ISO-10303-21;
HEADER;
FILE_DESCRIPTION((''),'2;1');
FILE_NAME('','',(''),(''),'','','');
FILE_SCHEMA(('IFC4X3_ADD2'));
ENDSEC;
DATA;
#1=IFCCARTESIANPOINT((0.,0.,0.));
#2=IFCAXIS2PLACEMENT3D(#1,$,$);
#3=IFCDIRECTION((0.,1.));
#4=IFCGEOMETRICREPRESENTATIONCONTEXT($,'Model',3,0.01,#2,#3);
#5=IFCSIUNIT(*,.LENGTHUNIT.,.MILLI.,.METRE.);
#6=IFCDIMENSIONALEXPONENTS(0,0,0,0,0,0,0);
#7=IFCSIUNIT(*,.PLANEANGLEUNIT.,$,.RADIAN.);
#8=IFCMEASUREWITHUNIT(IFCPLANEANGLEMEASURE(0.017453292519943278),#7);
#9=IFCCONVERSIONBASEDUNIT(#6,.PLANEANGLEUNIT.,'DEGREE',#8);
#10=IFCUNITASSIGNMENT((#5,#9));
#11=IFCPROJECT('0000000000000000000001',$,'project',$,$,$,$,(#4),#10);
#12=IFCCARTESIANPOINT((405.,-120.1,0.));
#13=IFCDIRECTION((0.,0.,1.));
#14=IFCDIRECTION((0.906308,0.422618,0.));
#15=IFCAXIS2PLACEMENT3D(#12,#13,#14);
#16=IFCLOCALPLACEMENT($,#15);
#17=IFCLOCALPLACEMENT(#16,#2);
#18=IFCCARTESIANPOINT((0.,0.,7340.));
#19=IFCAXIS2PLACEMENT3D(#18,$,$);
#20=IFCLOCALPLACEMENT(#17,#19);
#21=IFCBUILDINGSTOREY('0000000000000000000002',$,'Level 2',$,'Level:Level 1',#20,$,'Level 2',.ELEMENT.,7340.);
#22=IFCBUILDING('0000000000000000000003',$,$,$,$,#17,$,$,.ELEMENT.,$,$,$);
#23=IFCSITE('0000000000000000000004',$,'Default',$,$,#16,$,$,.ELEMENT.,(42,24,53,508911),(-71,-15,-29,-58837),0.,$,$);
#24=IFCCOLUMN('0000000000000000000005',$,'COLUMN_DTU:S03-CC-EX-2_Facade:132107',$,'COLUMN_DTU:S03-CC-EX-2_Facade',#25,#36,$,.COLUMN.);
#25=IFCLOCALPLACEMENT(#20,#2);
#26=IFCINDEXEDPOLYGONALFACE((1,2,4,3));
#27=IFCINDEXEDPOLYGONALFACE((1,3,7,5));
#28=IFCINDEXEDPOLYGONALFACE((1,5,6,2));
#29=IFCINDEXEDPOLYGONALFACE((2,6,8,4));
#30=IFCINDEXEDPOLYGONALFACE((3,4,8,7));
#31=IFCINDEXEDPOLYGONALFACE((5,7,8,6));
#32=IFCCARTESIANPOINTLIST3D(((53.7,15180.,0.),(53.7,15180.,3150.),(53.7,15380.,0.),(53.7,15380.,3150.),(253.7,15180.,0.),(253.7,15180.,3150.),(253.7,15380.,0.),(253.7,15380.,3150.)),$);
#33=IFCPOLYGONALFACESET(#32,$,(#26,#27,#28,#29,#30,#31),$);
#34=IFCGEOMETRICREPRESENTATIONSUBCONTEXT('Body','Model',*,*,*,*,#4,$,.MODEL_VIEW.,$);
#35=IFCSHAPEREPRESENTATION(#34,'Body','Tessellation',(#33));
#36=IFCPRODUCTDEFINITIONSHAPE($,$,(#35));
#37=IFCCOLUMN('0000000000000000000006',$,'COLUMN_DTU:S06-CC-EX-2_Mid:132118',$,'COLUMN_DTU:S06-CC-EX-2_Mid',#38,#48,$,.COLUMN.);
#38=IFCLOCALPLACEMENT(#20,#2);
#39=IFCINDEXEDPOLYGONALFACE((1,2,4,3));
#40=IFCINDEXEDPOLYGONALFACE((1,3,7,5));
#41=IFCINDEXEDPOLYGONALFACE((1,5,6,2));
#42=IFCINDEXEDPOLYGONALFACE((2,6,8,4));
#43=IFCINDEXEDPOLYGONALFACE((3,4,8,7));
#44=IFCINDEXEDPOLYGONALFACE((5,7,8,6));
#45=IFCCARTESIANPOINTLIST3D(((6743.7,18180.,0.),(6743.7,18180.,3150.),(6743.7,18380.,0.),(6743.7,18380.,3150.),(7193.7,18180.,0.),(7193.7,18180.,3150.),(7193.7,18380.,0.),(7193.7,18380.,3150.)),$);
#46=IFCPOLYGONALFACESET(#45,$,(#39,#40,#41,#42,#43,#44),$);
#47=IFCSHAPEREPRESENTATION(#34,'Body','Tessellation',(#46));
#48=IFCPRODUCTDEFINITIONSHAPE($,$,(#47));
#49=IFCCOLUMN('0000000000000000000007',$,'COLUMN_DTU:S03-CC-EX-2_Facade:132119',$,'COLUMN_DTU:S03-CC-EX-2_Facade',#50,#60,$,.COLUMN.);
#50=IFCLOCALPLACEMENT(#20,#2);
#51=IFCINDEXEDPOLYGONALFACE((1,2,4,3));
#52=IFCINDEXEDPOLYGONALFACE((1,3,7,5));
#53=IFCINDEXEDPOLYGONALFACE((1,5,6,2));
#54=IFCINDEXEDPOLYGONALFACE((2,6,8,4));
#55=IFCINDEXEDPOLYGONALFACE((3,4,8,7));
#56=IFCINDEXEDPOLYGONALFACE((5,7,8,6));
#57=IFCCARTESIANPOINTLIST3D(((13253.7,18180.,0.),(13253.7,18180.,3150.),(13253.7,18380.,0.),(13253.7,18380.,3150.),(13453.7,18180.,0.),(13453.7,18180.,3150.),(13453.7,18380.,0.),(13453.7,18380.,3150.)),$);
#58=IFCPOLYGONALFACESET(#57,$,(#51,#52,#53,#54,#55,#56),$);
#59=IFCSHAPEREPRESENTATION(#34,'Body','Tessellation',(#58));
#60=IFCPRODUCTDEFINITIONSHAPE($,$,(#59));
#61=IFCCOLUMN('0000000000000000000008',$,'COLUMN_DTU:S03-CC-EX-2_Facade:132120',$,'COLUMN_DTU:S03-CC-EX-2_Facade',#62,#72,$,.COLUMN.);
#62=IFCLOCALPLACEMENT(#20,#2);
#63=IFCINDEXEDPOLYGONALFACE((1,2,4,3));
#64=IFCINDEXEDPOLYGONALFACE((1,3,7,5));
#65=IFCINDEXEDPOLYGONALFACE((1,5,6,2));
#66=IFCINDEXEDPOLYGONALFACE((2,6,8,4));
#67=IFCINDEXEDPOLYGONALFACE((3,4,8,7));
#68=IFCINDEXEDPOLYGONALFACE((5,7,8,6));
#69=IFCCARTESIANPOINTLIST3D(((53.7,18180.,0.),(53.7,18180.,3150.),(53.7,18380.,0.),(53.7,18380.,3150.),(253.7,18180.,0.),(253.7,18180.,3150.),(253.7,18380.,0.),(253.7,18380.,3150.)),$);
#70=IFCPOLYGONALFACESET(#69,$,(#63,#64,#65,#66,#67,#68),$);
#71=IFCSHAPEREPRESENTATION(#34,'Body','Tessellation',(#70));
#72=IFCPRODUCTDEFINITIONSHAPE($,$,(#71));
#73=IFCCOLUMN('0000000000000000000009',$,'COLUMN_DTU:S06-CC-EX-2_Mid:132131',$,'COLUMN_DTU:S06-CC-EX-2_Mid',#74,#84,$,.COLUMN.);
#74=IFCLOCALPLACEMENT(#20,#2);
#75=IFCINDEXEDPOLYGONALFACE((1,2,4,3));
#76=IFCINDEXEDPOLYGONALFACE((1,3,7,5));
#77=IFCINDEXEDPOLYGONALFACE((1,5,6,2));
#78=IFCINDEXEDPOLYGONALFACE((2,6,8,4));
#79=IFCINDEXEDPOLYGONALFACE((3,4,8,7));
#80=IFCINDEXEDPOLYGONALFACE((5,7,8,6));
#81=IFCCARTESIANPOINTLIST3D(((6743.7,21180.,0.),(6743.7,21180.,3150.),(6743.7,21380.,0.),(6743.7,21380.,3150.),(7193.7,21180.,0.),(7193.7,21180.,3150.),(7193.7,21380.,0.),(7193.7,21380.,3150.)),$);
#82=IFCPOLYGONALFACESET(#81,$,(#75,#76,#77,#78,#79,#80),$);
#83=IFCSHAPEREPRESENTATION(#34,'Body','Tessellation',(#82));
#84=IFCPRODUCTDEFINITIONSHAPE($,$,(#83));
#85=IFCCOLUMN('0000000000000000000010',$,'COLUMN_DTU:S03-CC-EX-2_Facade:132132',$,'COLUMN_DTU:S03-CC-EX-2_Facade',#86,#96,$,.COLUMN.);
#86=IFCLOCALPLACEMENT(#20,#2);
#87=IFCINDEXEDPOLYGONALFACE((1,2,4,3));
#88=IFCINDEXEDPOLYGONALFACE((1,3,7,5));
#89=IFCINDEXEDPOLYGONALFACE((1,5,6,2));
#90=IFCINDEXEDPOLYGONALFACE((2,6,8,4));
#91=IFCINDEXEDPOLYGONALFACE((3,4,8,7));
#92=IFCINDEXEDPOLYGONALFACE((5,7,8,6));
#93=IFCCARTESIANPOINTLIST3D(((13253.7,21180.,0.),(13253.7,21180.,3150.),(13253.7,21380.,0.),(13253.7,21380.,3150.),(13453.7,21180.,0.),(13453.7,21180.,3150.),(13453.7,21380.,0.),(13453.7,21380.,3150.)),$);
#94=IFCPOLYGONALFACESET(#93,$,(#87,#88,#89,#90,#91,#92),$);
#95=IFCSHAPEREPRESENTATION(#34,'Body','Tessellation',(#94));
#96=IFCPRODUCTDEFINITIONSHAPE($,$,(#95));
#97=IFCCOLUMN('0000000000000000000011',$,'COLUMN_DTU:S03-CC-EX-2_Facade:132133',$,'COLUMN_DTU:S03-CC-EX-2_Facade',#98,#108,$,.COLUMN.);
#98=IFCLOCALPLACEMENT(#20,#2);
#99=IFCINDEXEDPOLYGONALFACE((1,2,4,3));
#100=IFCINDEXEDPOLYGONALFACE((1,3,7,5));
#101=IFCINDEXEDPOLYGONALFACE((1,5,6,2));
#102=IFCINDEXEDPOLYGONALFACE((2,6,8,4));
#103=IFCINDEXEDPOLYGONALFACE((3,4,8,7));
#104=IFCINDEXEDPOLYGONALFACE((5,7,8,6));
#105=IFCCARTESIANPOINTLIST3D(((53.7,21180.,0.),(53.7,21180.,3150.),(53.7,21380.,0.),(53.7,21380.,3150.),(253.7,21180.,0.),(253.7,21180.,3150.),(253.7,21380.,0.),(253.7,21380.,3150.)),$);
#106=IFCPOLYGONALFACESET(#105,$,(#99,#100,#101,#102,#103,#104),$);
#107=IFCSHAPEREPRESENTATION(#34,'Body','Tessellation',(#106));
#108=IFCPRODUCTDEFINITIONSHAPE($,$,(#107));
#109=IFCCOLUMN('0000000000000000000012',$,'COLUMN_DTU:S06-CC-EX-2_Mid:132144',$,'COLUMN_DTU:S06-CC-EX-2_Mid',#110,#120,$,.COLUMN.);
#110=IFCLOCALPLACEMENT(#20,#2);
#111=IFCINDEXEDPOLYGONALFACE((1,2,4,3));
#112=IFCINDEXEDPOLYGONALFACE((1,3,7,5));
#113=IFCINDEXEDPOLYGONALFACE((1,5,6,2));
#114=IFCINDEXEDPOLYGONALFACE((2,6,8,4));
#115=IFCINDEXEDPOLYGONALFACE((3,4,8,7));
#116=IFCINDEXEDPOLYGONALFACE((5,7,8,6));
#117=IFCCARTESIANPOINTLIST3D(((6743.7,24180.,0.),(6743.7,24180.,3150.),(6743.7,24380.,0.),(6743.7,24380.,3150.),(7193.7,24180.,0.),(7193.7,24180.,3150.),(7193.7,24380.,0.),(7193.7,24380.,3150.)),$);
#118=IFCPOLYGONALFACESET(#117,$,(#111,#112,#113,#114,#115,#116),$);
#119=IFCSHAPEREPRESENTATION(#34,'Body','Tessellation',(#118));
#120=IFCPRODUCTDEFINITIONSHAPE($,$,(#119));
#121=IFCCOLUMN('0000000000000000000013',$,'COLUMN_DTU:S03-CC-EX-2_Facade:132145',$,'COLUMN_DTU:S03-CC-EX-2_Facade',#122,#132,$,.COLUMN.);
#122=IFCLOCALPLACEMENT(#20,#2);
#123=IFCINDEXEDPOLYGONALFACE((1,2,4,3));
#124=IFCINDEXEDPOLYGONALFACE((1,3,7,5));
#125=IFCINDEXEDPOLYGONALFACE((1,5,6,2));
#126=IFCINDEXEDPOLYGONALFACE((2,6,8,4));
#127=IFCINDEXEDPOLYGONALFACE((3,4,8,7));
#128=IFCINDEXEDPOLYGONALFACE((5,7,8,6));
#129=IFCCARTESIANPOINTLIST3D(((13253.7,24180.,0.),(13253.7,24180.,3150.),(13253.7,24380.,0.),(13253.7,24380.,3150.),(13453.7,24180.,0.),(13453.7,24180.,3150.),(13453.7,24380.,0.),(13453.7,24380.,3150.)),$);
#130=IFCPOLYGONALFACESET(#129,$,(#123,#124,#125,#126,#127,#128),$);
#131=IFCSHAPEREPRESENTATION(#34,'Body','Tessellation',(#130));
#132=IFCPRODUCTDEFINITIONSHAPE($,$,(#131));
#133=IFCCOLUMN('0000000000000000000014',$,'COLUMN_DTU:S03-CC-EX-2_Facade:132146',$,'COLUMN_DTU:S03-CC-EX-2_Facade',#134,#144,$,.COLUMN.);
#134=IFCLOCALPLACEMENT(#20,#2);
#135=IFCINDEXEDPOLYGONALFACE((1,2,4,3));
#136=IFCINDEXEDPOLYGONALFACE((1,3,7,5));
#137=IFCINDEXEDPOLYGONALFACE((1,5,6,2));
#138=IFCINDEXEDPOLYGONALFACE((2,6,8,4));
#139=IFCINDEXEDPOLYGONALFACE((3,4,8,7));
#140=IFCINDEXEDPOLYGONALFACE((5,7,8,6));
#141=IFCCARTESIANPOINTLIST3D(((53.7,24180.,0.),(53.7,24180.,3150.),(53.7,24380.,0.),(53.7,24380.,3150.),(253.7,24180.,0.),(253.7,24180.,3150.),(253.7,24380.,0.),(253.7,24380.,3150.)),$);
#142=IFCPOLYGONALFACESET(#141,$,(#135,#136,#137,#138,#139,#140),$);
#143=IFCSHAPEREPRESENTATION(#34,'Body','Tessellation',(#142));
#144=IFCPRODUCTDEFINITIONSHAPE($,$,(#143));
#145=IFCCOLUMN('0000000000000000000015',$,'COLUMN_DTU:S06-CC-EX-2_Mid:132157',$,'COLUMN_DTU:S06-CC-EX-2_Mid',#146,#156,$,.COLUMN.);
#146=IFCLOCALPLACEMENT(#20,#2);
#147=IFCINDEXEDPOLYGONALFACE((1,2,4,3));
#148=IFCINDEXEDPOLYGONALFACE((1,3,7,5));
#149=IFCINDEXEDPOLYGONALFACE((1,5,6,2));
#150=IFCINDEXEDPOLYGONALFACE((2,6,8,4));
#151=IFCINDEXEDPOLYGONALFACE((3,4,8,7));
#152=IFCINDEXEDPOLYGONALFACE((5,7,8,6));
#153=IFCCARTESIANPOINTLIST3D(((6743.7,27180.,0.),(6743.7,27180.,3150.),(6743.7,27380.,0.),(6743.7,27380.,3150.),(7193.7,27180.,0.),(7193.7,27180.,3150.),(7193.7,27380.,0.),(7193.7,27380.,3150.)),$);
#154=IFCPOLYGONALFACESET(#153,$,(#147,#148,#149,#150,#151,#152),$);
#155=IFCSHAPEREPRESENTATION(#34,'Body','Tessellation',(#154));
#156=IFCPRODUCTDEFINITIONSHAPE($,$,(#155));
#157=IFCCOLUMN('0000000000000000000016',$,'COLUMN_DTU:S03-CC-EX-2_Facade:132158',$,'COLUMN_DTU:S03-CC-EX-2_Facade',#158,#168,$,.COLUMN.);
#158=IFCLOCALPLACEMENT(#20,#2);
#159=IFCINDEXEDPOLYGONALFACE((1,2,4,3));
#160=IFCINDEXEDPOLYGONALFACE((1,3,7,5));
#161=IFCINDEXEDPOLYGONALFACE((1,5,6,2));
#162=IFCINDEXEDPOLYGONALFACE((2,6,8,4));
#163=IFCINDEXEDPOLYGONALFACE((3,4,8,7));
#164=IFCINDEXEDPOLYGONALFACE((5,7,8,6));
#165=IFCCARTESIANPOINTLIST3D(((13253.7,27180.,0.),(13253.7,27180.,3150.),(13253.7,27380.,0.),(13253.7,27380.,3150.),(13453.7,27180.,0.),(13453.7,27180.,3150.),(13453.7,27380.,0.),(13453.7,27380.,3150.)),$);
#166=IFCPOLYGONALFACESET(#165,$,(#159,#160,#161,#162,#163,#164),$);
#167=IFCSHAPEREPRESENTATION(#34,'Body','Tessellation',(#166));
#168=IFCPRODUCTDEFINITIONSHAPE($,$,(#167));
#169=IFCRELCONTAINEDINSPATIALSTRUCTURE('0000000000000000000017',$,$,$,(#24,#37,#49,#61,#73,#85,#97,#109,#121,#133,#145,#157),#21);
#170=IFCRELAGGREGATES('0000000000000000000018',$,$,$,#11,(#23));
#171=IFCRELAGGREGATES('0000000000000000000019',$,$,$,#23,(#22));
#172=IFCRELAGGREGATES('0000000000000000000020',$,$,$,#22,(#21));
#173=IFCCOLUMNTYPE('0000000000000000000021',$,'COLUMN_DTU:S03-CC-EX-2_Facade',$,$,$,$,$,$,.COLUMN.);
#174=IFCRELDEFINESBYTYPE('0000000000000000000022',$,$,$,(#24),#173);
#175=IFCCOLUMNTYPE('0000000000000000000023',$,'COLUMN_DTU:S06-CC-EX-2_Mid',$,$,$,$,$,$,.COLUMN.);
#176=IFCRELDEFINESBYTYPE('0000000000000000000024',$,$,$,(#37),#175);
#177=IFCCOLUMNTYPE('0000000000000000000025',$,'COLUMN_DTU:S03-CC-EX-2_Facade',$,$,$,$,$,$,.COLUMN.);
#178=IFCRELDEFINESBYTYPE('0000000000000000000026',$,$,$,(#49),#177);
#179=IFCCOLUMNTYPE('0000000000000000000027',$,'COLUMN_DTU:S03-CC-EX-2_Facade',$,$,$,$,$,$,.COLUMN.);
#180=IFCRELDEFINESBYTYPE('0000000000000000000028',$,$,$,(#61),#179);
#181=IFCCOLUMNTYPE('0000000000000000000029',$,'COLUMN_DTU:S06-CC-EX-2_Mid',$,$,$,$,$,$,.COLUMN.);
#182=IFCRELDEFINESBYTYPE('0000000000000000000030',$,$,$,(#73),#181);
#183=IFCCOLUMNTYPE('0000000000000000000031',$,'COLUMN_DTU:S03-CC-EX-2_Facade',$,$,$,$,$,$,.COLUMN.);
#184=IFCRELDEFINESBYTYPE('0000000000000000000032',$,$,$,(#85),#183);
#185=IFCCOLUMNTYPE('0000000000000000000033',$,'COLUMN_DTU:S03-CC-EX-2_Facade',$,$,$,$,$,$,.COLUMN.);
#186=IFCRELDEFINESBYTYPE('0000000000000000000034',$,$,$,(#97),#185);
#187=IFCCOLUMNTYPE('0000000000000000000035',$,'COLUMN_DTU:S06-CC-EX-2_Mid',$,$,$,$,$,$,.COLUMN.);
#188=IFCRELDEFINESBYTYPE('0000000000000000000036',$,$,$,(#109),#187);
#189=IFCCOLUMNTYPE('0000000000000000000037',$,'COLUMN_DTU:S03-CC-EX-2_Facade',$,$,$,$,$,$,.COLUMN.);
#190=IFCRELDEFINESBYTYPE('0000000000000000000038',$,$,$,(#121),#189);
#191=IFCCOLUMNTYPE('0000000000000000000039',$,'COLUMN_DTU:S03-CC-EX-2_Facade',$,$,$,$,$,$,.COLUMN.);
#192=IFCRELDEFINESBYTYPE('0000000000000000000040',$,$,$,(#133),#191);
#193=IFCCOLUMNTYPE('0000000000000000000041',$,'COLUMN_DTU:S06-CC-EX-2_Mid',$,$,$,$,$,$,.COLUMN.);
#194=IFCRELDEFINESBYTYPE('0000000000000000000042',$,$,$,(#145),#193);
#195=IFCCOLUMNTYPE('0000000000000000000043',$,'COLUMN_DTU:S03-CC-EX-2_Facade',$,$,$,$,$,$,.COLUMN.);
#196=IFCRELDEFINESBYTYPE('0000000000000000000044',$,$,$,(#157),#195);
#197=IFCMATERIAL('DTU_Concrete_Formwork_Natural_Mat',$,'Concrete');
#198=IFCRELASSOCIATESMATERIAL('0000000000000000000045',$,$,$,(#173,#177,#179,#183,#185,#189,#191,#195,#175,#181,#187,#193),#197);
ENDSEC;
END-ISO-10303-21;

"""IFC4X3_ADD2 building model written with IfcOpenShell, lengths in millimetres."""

from ifc_helpers import new_model, entity, si_unit, converted_unit, direction, frame, frame_2d, origin, origin_2d_with_axis, place, context, subcontext, project, spatial, rectangle, extrude, source, transform, mapped, material, material_profile, profile_set, type_object, type_shapes, element, save


model = new_model("IFC4X3_ADD2")

# Units and contexts
model_context = context("Model", 3, precision=0.01, world=origin(), true_north=direction((0.0, 1.0)))
body_context = subcontext(model_context, "Body", "Model", "MODEL_VIEW")
ifc_project = project(units=[si_unit("LENGTHUNIT", "METRE", prefix="MILLI"), converted_unit("PLANEANGLEUNIT", "DEGREE", entity("IfcPlaneAngleMeasure", 0.017453292519943278), si_unit("PLANEANGLEUNIT", "RADIAN"), dimensions=[0, 0, 0, 0, 0, 0, 0])], contexts=[model_context])

# Site, building, storey
site_placement = place(None, frame((405.0, -120.1, 0.0), z_axis=(0.0, 0.0, 1.0), x_axis=(0.906308, 0.422618, 0.0)))
site = spatial("IfcSite", under=ifc_project, at=site_placement, Name="Default", CompositionType="ELEMENT", RefLatitude=(42, 24, 53, 508911), RefLongitude=(-71, -15, -29, -58837), RefElevation=0.0)
building_placement = place(site_placement, origin())
building = spatial("IfcBuilding", under=site, at=building_placement, CompositionType="ELEMENT")
storey_placement = place(building_placement, frame((0.0, 0.0, 7340.0)))
storey = spatial("IfcBuildingStorey", under=building, at=storey_placement, Name="Level 2", ObjectType="Level:Level 1", LongName="Level 2", CompositionType="ELEMENT", Elevation=7340.0)

# Columns
ifc_material = material(Name="DTU_Concrete_Formwork_Natural_Mat", Category="Concrete")
ifc_material_profile_1 = material_profile(ifc_material, rectangle(XDim=200.0, YDim=200.0, at=frame_2d((0.0, 0.0), x_axis=(1.0, 0.0))), Name="S03-CC-EX-2_Facade")
ifc_profile_set_1 = profile_set([ifc_material_profile_1], Name="S03-CC-EX-2_Facade")
ifc_material_profile_2 = material_profile(ifc_material, rectangle(XDim=200.0, YDim=450.0, at=origin_2d_with_axis()), Name="S06-CC-EX-2_Mid")
ifc_profile_set_2 = profile_set([ifc_material_profile_2], Name="S06-CC-EX-2_Mid")
column_type_1 = type_object("IfcColumnType", Name="COLUMN_DTU:S03-CC-EX-2_Facade", PredefinedType="COLUMN", material=ifc_profile_set_1)
shared_shape_1 = source(origin(), body_context, "Body", "SweptSolid", [
    extrude(rectangle(XDim=200.0, YDim=200.0, at=frame_2d((0.0, 0.0), x_axis=(1.0, 0.0))), frame((153.7, 15280.0, 7340.0), z_axis=(0.0, 0.0, 1.0), x_axis=(0.0, -1.0, 0.0)), (0.0, 0.0, 1.0), 3150.0),
])
type_shapes(column_type_1, [shared_shape_1])
column_1_placement = place(storey_placement, frame((0.0, 0.0, -7340.0)))
element("IfcColumn", 1, at=column_1_placement, inside=storey, type_object=column_type_1, Name="COLUMN_DTU:S03-CC-EX-2_Facade:132107", ObjectType="COLUMN_DTU:S03-CC-EX-2_Facade", PredefinedType="COLUMN", context=body_context, shape_type="MappedRepresentation", body=[
    mapped(shared_shape_1, transform((0.0, 0.0, 0.0), scale=1.0)),
])
column_type_2 = type_object("IfcColumnType", Name="COLUMN_DTU:S06-CC-EX-2_Mid", PredefinedType="COLUMN", material=ifc_profile_set_2)
shared_shape_2 = source(origin(), body_context, "Body", "SweptSolid", [
    extrude(rectangle(XDim=200.0, YDim=450.0, at=frame_2d((0.0, 0.0), x_axis=(1.0, 0.0))), frame((6968.7, 18280.0, 7340.0), z_axis=(0.0, 0.0, 1.0), x_axis=(0.0, 1.0, 0.0)), (0.0, 0.0, 1.0), 3150.0),
])
type_shapes(column_type_2, [shared_shape_2])
column_2_placement = place(storey_placement, frame((0.0, 0.0, -7340.0)))
element("IfcColumn", 2, at=column_2_placement, inside=storey, type_object=column_type_2, Name="COLUMN_DTU:S06-CC-EX-2_Mid:132118", ObjectType="COLUMN_DTU:S06-CC-EX-2_Mid", PredefinedType="COLUMN", context=body_context, shape_type="MappedRepresentation", body=[
    mapped(shared_shape_2, transform((0.0, 0.0, 0.0), scale=1.0)),
])
column_type_3 = type_object("IfcColumnType", Name="COLUMN_DTU:S03-CC-EX-2_Facade", PredefinedType="COLUMN", material=ifc_profile_set_1)
shared_shape_3 = source(origin(), body_context, "Body", "SweptSolid", [
    extrude(rectangle(XDim=200.0, YDim=200.0, at=frame_2d((0.0, 0.0), x_axis=(1.0, 0.0))), frame((13353.7, 18280.0, 7340.0), z_axis=(0.0, 0.0, 1.0), x_axis=(0.0, -1.0, 0.0)), (0.0, 0.0, 1.0), 3150.0),
])
type_shapes(column_type_3, [shared_shape_3])
column_3_placement = place(storey_placement, frame((0.0, 0.0, -7340.0)))
element("IfcColumn", 3, at=column_3_placement, inside=storey, type_object=column_type_3, Name="COLUMN_DTU:S03-CC-EX-2_Facade:132119", ObjectType="COLUMN_DTU:S03-CC-EX-2_Facade", PredefinedType="COLUMN", context=body_context, shape_type="MappedRepresentation", body=[
    mapped(shared_shape_3, transform((0.0, 0.0, 0.0), scale=1.0)),
])
column_type_4 = type_object("IfcColumnType", Name="COLUMN_DTU:S03-CC-EX-2_Facade", PredefinedType="COLUMN", material=ifc_profile_set_1)
shared_shape_4 = source(origin(), body_context, "Body", "SweptSolid", [
    extrude(rectangle(XDim=200.0, YDim=200.0, at=frame_2d((0.0, 0.0), x_axis=(1.0, 0.0))), frame((153.7, 18280.0, 7340.0), z_axis=(0.0, 0.0, 1.0), x_axis=(0.0, -1.0, 0.0)), (0.0, 0.0, 1.0), 3150.0),
])
type_shapes(column_type_4, [shared_shape_4])
column_4_placement = place(storey_placement, frame((0.0, 0.0, -7340.0)))
element("IfcColumn", 4, at=column_4_placement, inside=storey, type_object=column_type_4, Name="COLUMN_DTU:S03-CC-EX-2_Facade:132120", ObjectType="COLUMN_DTU:S03-CC-EX-2_Facade", PredefinedType="COLUMN", context=body_context, shape_type="MappedRepresentation", body=[
    mapped(shared_shape_4, transform((0.0, 0.0, 0.0), scale=1.0)),
])
column_type_5 = type_object("IfcColumnType", Name="COLUMN_DTU:S06-CC-EX-2_Mid", PredefinedType="COLUMN", material=ifc_profile_set_2)
shared_shape_5 = source(origin(), body_context, "Body", "SweptSolid", [
    extrude(rectangle(XDim=200.0, YDim=450.0, at=origin_2d_with_axis()), frame((6968.7, 21280.0, 7340.0), z_axis=(0.0, 0.0, 1.0), x_axis=(0.0, 1.0, 0.0)), (0.0, 0.0, 1.0), 3150.0),
])
type_shapes(column_type_5, [shared_shape_5])
column_5_placement = place(storey_placement, frame((0.0, 0.0, -7340.0)))
element("IfcColumn", 5, at=column_5_placement, inside=storey, type_object=column_type_5, Name="COLUMN_DTU:S06-CC-EX-2_Mid:132131", ObjectType="COLUMN_DTU:S06-CC-EX-2_Mid", PredefinedType="COLUMN", context=body_context, shape_type="MappedRepresentation", body=[
    mapped(shared_shape_5, transform((0.0, 0.0, 0.0), scale=1.0)),
])
column_type_6 = type_object("IfcColumnType", Name="COLUMN_DTU:S03-CC-EX-2_Facade", PredefinedType="COLUMN", material=ifc_profile_set_1)
shared_shape_6 = source(origin(), body_context, "Body", "SweptSolid", [
    extrude(rectangle(XDim=200.0, YDim=200.0, at=frame_2d((0.0, 0.0), x_axis=(1.0, 0.0))), frame((13353.7, 21280.0, 7340.0), z_axis=(0.0, 0.0, 1.0), x_axis=(0.0, -1.0, 0.0)), (0.0, 0.0, 1.0), 3150.0),
])
type_shapes(column_type_6, [shared_shape_6])
column_6_placement = place(storey_placement, frame((0.0, 0.0, -7340.0)))
element("IfcColumn", 6, at=column_6_placement, inside=storey, type_object=column_type_6, Name="COLUMN_DTU:S03-CC-EX-2_Facade:132132", ObjectType="COLUMN_DTU:S03-CC-EX-2_Facade", PredefinedType="COLUMN", context=body_context, shape_type="MappedRepresentation", body=[
    mapped(shared_shape_6, transform((0.0, 0.0, 0.0), scale=1.0)),
])
column_type_7 = type_object("IfcColumnType", Name="COLUMN_DTU:S03-CC-EX-2_Facade", PredefinedType="COLUMN", material=ifc_profile_set_1)
shared_shape_7 = source(origin(), body_context, "Body", "SweptSolid", [
    extrude(rectangle(XDim=200.0, YDim=200.0, at=frame_2d((0.0, 0.0), x_axis=(1.0, 0.0))), frame((153.7, 21280.0, 7340.0), z_axis=(0.0, 0.0, 1.0), x_axis=(0.0, -1.0, 0.0)), (0.0, 0.0, 1.0), 3150.0),
])
type_shapes(column_type_7, [shared_shape_7])
column_7_placement = place(storey_placement, frame((0.0, 0.0, -7340.0)))
element("IfcColumn", 7, at=column_7_placement, inside=storey, type_object=column_type_7, Name="COLUMN_DTU:S03-CC-EX-2_Facade:132133", ObjectType="COLUMN_DTU:S03-CC-EX-2_Facade", PredefinedType="COLUMN", context=body_context, shape_type="MappedRepresentation", body=[
    mapped(shared_shape_7, transform((0.0, 0.0, 0.0), scale=1.0)),
])
column_type_8 = type_object("IfcColumnType", Name="COLUMN_DTU:S06-CC-EX-2_Mid", PredefinedType="COLUMN", material=ifc_profile_set_2)
shared_shape_8 = source(origin(), body_context, "Body", "SweptSolid", [
    extrude(rectangle(XDim=200.0, YDim=450.0, at=origin_2d_with_axis()), frame((6968.7, 24280.0, 7340.0), z_axis=(0.0, 0.0, 1.0), x_axis=(0.0, 1.0, 0.0)), (0.0, 0.0, 1.0), 3150.0),
])
type_shapes(column_type_8, [shared_shape_8])
column_8_placement = place(storey_placement, frame((0.0, 0.0, -7340.0)))
element("IfcColumn", 8, at=column_8_placement, inside=storey, type_object=column_type_8, Name="COLUMN_DTU:S06-CC-EX-2_Mid:132144", ObjectType="COLUMN_DTU:S06-CC-EX-2_Mid", PredefinedType="COLUMN", context=body_context, shape_type="MappedRepresentation", body=[
    mapped(shared_shape_8, transform((0.0, 0.0, 0.0), scale=1.0)),
])
column_type_9 = type_object("IfcColumnType", Name="COLUMN_DTU:S03-CC-EX-2_Facade", PredefinedType="COLUMN", material=ifc_profile_set_1)
shared_shape_9 = source(origin(), body_context, "Body", "SweptSolid", [
    extrude(rectangle(XDim=200.0, YDim=200.0, at=frame_2d((0.0, 0.0), x_axis=(1.0, 0.0))), frame((13353.7, 24280.0, 7340.0), z_axis=(0.0, 0.0, 1.0), x_axis=(0.0, -1.0, 0.0)), (0.0, 0.0, 1.0), 3150.0),
])
type_shapes(column_type_9, [shared_shape_9])
column_9_placement = place(storey_placement, frame((0.0, 0.0, -7340.0)))
element("IfcColumn", 9, at=column_9_placement, inside=storey, type_object=column_type_9, Name="COLUMN_DTU:S03-CC-EX-2_Facade:132145", ObjectType="COLUMN_DTU:S03-CC-EX-2_Facade", PredefinedType="COLUMN", context=body_context, shape_type="MappedRepresentation", body=[
    mapped(shared_shape_9, transform((0.0, 0.0, 0.0), scale=1.0)),
])
column_type_10 = type_object("IfcColumnType", Name="COLUMN_DTU:S03-CC-EX-2_Facade", PredefinedType="COLUMN", material=ifc_profile_set_1)
shared_shape_10 = source(origin(), body_context, "Body", "SweptSolid", [
    extrude(rectangle(XDim=200.0, YDim=200.0, at=frame_2d((0.0, 0.0), x_axis=(1.0, 0.0))), frame((153.7, 24280.0, 7340.0), z_axis=(0.0, 0.0, 1.0), x_axis=(0.0, -1.0, 0.0)), (0.0, 0.0, 1.0), 3150.0),
])
type_shapes(column_type_10, [shared_shape_10])
column_10_placement = place(storey_placement, frame((0.0, 0.0, -7340.0)))
element("IfcColumn", 10, at=column_10_placement, inside=storey, type_object=column_type_10, Name="COLUMN_DTU:S03-CC-EX-2_Facade:132146", ObjectType="COLUMN_DTU:S03-CC-EX-2_Facade", PredefinedType="COLUMN", context=body_context, shape_type="MappedRepresentation", body=[
    mapped(shared_shape_10, transform((0.0, 0.0, 0.0), scale=1.0)),
])
column_type_11 = type_object("IfcColumnType", Name="COLUMN_DTU:S06-CC-EX-2_Mid", PredefinedType="COLUMN", material=ifc_profile_set_2)
shared_shape_11 = source(origin(), body_context, "Body", "SweptSolid", [
    extrude(rectangle(XDim=200.0, YDim=450.0, at=origin_2d_with_axis()), frame((6968.7, 27280.0, 7340.0), z_axis=(0.0, 0.0, 1.0), x_axis=(0.0, 1.0, 0.0)), (0.0, 0.0, 1.0), 3150.0),
])
type_shapes(column_type_11, [shared_shape_11])
column_11_placement = place(storey_placement, frame((0.0, 0.0, -7340.0)))
element("IfcColumn", 11, at=column_11_placement, inside=storey, type_object=column_type_11, Name="COLUMN_DTU:S06-CC-EX-2_Mid:132157", ObjectType="COLUMN_DTU:S06-CC-EX-2_Mid", PredefinedType="COLUMN", context=body_context, shape_type="MappedRepresentation", body=[
    mapped(shared_shape_11, transform((0.0, 0.0, 0.0), scale=1.0)),
])
column_type_12 = type_object("IfcColumnType", Name="COLUMN_DTU:S03-CC-EX-2_Facade", PredefinedType="COLUMN", material=ifc_profile_set_1)
shared_shape_12 = source(origin(), body_context, "Body", "SweptSolid", [
    extrude(rectangle(XDim=200.0, YDim=200.0, at=frame_2d((0.0, 0.0), x_axis=(1.0, 0.0))), frame((13353.7, 27280.0, 7340.0), z_axis=(0.0, 0.0, 1.0), x_axis=(0.0, -1.0, 0.0)), (0.0, 0.0, 1.0), 3150.0),
])
type_shapes(column_type_12, [shared_shape_12])
column_12_placement = place(storey_placement, frame((0.0, 0.0, -7340.0)))
element("IfcColumn", 12, at=column_12_placement, inside=storey, type_object=column_type_12, Name="COLUMN_DTU:S03-CC-EX-2_Facade:132158", ObjectType="COLUMN_DTU:S03-CC-EX-2_Facade", PredefinedType="COLUMN", context=body_context, shape_type="MappedRepresentation", body=[
    mapped(shared_shape_12, transform((0.0, 0.0, 0.0), scale=1.0)),
])

save(model, "model.ifc")
